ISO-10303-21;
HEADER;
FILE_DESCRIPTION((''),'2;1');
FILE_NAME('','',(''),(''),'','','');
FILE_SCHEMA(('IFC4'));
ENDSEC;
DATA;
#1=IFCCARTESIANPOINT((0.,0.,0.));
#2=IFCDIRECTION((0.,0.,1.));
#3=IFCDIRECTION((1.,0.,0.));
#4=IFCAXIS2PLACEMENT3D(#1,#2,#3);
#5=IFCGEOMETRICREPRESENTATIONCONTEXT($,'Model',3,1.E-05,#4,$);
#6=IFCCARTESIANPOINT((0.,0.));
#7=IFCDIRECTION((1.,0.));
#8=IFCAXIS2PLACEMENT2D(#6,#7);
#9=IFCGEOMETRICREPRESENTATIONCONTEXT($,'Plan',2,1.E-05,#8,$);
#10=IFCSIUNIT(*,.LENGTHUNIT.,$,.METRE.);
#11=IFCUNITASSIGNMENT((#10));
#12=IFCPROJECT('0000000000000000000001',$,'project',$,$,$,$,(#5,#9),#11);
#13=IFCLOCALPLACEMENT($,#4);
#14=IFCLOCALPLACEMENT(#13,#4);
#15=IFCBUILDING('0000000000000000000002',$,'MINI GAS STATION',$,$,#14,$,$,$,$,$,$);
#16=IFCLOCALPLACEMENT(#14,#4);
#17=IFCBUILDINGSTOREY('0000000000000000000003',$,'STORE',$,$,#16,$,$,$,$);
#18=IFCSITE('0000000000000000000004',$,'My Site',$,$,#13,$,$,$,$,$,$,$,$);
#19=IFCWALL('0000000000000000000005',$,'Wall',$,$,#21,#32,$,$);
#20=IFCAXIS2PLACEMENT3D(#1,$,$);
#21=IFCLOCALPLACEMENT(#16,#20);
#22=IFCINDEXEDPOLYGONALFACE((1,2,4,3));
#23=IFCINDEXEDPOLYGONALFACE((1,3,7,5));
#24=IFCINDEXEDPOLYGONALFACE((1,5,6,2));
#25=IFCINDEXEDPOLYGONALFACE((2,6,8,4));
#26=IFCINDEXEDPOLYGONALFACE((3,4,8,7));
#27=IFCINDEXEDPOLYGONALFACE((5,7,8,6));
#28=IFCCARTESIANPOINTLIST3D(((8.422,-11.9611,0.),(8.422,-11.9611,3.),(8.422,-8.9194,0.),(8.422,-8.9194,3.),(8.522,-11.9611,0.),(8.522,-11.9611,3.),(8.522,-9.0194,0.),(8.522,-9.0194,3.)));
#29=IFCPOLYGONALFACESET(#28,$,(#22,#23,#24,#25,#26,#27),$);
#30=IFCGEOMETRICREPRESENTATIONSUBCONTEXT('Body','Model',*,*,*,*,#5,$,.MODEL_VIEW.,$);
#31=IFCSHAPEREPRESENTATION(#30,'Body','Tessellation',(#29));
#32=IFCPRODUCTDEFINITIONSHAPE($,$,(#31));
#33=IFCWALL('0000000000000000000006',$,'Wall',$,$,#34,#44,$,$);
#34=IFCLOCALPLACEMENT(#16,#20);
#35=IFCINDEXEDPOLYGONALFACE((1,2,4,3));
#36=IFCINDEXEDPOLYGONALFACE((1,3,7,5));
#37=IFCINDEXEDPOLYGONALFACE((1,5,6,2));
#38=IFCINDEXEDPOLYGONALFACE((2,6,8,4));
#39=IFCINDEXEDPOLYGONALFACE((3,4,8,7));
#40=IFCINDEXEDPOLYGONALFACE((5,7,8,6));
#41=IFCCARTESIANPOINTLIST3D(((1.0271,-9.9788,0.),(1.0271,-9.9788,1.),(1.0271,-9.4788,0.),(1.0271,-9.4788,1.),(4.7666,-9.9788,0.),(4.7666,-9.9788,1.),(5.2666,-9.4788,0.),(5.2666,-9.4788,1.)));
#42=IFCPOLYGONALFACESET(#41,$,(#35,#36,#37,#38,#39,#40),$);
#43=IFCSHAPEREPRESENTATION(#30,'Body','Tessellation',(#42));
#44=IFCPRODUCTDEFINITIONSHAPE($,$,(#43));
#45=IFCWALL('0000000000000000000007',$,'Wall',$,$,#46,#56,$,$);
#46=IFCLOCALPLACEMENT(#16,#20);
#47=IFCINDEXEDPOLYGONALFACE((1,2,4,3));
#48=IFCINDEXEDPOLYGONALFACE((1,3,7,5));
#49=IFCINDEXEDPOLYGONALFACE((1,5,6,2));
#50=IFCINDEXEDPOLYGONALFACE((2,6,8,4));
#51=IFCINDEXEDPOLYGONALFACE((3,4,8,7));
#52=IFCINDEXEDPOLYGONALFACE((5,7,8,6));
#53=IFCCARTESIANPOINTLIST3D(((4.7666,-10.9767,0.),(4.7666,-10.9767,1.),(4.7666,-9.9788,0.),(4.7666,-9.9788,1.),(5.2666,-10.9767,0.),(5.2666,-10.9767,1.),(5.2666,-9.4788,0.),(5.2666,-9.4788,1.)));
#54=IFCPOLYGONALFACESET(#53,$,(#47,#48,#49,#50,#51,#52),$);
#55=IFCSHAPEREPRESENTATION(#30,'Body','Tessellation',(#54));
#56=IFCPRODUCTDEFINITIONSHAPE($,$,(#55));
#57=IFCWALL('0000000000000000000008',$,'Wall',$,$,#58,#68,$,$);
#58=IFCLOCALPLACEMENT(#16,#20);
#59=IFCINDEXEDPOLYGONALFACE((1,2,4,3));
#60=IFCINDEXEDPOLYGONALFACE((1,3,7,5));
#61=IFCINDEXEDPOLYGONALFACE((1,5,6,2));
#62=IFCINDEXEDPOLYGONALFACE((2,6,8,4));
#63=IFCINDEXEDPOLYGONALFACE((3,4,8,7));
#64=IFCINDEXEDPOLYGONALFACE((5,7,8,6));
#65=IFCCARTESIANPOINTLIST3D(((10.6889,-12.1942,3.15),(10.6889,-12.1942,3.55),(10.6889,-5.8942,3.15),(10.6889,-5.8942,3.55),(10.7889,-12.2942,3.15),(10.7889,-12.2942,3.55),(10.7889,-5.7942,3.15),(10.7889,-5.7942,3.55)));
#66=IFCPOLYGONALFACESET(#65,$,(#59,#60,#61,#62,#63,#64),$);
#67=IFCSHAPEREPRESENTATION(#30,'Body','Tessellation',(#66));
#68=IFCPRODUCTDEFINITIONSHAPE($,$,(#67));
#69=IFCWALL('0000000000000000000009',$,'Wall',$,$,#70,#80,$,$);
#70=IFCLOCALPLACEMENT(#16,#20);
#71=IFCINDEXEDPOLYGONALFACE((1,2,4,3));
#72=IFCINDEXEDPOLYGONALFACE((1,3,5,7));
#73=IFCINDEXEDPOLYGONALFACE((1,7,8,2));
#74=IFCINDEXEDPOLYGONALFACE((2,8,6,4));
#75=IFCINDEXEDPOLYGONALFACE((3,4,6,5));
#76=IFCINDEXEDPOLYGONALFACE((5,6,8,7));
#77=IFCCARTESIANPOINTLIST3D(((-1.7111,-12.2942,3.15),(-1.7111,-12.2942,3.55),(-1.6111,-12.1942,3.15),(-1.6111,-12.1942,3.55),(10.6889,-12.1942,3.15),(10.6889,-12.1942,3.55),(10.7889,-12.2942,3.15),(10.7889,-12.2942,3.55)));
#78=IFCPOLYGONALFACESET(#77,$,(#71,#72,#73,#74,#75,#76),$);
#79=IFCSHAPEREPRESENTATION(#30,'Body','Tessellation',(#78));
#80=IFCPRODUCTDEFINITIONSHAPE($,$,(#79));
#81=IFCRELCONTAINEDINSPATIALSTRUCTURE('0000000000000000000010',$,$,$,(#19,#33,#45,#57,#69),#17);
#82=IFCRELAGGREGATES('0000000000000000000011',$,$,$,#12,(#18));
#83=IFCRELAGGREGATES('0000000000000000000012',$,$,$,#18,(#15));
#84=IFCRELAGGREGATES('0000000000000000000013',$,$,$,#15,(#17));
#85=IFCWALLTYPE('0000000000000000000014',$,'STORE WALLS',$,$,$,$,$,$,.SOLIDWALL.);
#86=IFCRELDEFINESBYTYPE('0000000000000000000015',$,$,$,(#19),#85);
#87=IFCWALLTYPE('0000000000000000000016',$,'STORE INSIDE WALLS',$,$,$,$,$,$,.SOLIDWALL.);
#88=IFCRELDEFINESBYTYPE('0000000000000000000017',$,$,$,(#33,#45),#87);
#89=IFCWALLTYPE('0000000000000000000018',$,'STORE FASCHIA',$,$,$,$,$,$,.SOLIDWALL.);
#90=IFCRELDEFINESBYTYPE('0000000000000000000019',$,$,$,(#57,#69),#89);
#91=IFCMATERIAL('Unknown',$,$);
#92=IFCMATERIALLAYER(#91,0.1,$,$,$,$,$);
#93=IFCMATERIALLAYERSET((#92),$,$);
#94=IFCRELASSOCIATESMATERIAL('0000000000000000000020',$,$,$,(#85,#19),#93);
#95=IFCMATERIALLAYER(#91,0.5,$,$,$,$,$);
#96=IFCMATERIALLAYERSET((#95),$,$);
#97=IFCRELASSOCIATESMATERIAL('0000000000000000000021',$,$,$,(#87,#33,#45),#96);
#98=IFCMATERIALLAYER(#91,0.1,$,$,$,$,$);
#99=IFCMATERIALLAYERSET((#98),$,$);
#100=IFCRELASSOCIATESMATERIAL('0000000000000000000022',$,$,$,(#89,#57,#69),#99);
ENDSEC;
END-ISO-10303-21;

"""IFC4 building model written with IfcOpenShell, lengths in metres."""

from ifc_helpers import new_model, si_unit, frame, origin_with_axes, origin_2d_with_axis, place, context, subcontext, project, spatial, line, indexed_curve, outline, extrude, material, layer, layer_set, layer_usage, type_object, element, save


model = new_model("IFC4")

# Units and contexts
model_context = context("Model", 3, precision=1e-05, world=origin_with_axes())
plan_context = context("Plan", 2, precision=1e-05, world=origin_2d_with_axis())
body_context_1 = subcontext(model_context, "Body", "Model", "MODEL_VIEW")
ifc_project = project(units=[si_unit("LENGTHUNIT", "METRE")], contexts=[model_context, plan_context])

# Site, building, storey
site_placement = place(None, origin_with_axes())
site = spatial("IfcSite", under=ifc_project, at=site_placement, Name="My Site")
building_placement = place(site_placement, origin_with_axes())
building = spatial("IfcBuilding", under=site, at=building_placement, Name="MINI GAS STATION")
storey_placement = place(building_placement, origin_with_axes())
storey = spatial("IfcBuildingStorey", under=building, at=storey_placement, Name="STORE")

# Shared definitions
ifc_material = material(Name="Unknown")

# Shared definitions
ifc_layer_1 = layer(ifc_material, 0.1)
ifc_layer_set_1 = layer_set([ifc_layer_1])
wall_type_1 = type_object("IfcWallType", Name="STORE WALLS", PredefinedType="SOLIDWALL", material=ifc_layer_set_1)

# Walls
ifc_layer_usage_1 = layer_usage(ifc_layer_set_1, "AXIS2", "POSITIVE", 0.0)
wall_1_placement = place(storey_placement, frame((8.422, -8.9194, 0.0), z_axis=(0.0, 0.0, 1.0), x_axis=(0.0, -1.0, 0.0)))
element("IfcWall", 1, at=wall_1_placement, inside=storey, type_object=wall_type_1, material=ifc_layer_usage_1, Name="Wall", context=body_context_1, shape_type="SweptSolid", body=[
    extrude(outline(indexed_curve([(0.0, 0.0), (0.1, 0.1), (3.0417, 0.1), (3.0417, 0.0)], segments=[line(1, 2, 3, 4, 1)])), origin_with_axes(), (0.0, 0.0, 1.0), 3.0),
])
ifc_layer_2 = layer(ifc_material, 0.5)
ifc_layer_set_2 = layer_set([ifc_layer_2])
ifc_layer_usage_2 = layer_usage(ifc_layer_set_2, "AXIS2", "POSITIVE", 0.0)
wall_type_2 = type_object("IfcWallType", Name="STORE INSIDE WALLS", PredefinedType="SOLIDWALL", material=ifc_layer_set_2)
wall_2_placement = place(storey_placement, frame((1.0271, -9.9788, 0.0), z_axis=(0.0, 0.0, 1.0), x_axis=(1.0, 0.0, 0.0)))
element("IfcWall", 2, at=wall_2_placement, inside=storey, type_object=wall_type_2, material=ifc_layer_usage_2, Name="Wall", context=body_context_1, shape_type="SweptSolid", body=[
    extrude(outline(indexed_curve([(0.0, 0.0), (0.0, 0.5), (4.2395, 0.5), (3.7395, 0.0)], segments=[line(1, 2, 3, 4, 1)])), origin_with_axes(), (0.0, 0.0, 1.0), 1.0),
])
ifc_layer_usage_3 = layer_usage(ifc_layer_set_2, "AXIS2", "POSITIVE", 0.0)
wall_3_placement = place(storey_placement, frame((4.7666, -9.9788, 0.0), z_axis=(0.0, 0.0, 1.0), x_axis=(0.0, -1.0, 0.0)))
element("IfcWall", 3, at=wall_3_placement, inside=storey, type_object=wall_type_2, material=ifc_layer_usage_3, Name="Wall", context=body_context_1, shape_type="SweptSolid", body=[
    extrude(outline(indexed_curve([(0.0, 0.0), (-0.5, 0.5), (0.9979, 0.5), (0.9979, 0.0)], segments=[line(1, 2, 3, 4, 1)])), origin_with_axes(), (0.0, 0.0, 1.0), 1.0),
])
ifc_layer_3 = layer(ifc_material, 0.1)
ifc_layer_set_3 = layer_set([ifc_layer_3])
ifc_layer_usage_4 = layer_usage(ifc_layer_set_3, "AXIS2", "POSITIVE", 0.0)
wall_type_3 = type_object("IfcWallType", Name="STORE FASCHIA", PredefinedType="SOLIDWALL", material=ifc_layer_set_3)
wall_4_placement = place(storey_placement, frame((10.6889, -5.8942, 3.15), z_axis=(0.0, 0.0, 1.0), x_axis=(0.0, -1.0, 0.0)))
element("IfcWall", 4, at=wall_4_placement, inside=storey, type_object=wall_type_3, material=ifc_layer_usage_4, Name="Wall", context=body_context_1, shape_type="SweptSolid", body=[
    extrude(outline(indexed_curve([(0.0, 0.0), (-0.1, 0.1), (6.4, 0.1), (6.3, 0.0)], segments=[line(1, 2, 3, 4, 1)])), origin_with_axes(), (0.0, 0.0, 1.0), 0.4),
])
ifc_layer_usage_5 = layer_usage(ifc_layer_set_3, "AXIS2", "POSITIVE", 0.0)
wall_5_placement = place(storey_placement, frame((10.6889, -12.1942, 3.15), z_axis=(0.0, 0.0, 1.0), x_axis=(-1.0, 0.0, 0.0)))
element("IfcWall", 5, at=wall_5_placement, inside=storey, type_object=wall_type_3, material=ifc_layer_usage_5, Name="Wall", context=body_context_1, shape_type="SweptSolid", body=[
    extrude(outline(indexed_curve([(0.0, 0.0), (-0.1, 0.1), (12.4, 0.1), (12.3, 0.0)], segments=[line(1, 2, 3, 4, 1)])), origin_with_axes(), (0.0, 0.0, 1.0), 0.4),
])

save(model, "model.ifc")
